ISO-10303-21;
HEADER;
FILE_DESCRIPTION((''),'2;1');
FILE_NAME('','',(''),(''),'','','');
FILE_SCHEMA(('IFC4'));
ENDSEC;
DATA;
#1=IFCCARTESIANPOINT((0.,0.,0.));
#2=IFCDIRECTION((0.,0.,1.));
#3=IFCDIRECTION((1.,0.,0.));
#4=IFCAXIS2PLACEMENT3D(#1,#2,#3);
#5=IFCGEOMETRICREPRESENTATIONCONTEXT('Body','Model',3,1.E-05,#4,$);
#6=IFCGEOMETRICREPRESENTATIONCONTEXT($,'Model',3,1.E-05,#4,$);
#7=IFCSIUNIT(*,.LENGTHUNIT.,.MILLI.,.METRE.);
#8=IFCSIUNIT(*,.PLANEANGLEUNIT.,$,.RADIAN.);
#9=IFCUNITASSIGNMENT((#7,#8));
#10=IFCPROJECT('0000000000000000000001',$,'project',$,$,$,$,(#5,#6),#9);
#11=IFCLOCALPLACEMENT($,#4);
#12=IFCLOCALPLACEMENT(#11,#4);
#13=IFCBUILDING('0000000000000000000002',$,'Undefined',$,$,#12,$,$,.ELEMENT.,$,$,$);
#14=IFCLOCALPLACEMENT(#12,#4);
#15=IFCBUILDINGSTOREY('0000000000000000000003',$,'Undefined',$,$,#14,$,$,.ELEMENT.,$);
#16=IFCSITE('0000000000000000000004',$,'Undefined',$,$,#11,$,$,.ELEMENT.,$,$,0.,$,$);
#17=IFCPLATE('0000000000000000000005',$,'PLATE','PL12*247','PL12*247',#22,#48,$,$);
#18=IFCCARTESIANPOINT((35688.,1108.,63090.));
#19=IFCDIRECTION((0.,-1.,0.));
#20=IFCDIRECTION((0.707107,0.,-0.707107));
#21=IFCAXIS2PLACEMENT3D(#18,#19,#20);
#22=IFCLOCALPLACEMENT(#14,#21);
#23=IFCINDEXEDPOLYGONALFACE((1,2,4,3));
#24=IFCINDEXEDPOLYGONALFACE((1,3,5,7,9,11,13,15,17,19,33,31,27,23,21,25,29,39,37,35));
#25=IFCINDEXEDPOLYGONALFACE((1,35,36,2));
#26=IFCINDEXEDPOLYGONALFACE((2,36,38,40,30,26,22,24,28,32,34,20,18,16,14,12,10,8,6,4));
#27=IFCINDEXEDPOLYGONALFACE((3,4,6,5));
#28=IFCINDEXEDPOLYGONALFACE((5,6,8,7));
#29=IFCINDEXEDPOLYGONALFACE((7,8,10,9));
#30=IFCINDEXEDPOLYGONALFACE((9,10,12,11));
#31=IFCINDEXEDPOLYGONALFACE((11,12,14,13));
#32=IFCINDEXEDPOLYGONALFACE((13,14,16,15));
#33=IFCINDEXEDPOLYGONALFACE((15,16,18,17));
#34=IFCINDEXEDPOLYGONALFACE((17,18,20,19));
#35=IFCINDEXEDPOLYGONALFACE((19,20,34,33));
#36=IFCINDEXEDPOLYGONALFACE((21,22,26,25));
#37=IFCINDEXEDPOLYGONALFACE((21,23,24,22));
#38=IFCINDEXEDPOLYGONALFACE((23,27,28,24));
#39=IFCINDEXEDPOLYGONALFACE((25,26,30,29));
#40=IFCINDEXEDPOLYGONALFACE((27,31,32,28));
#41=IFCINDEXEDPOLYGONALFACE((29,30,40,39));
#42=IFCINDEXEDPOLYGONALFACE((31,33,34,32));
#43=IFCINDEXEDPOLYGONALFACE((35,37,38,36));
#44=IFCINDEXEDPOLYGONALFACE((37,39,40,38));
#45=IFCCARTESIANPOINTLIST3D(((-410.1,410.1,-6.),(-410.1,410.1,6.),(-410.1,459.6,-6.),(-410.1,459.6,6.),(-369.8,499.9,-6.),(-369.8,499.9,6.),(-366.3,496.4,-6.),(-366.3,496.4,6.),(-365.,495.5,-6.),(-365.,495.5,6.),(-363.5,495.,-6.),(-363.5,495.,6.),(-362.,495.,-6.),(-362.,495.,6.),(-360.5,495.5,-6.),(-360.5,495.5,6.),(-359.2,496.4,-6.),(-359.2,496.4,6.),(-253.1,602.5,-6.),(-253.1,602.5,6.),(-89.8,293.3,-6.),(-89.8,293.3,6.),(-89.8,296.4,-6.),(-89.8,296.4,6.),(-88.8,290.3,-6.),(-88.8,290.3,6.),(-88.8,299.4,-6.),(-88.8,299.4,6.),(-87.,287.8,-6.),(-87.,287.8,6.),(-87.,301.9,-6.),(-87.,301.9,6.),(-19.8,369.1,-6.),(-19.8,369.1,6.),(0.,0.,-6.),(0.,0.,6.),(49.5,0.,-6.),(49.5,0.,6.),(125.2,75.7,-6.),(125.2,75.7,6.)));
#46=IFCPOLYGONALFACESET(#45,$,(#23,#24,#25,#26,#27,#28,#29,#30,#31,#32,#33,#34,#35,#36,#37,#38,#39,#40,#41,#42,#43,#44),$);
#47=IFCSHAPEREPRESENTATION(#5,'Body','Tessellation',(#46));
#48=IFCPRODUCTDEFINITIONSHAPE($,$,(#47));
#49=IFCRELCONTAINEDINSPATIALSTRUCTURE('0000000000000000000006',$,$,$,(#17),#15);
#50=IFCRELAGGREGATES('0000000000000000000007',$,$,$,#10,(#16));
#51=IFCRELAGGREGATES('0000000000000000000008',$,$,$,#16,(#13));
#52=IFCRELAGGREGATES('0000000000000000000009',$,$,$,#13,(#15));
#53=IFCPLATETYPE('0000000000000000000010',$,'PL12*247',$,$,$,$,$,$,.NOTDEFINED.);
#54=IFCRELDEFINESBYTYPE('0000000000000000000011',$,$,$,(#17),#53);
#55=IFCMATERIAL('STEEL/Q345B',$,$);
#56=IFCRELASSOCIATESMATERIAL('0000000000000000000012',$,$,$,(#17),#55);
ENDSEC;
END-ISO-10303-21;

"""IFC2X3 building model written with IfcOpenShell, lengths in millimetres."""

from ifc_helpers import new_model, si_unit, frame, origin_with_axes, place, context, project, spatial, polyline, outline, extrude, material, type_object, element, save


model = new_model("IFC2X3")

# Units and contexts
model_context_1 = context("Model", 3, precision=1e-05, world=origin_with_axes(), identifier="Body")
model_context_2 = context("Model", 3, precision=1e-05, world=origin_with_axes())
ifc_project = project(units=[si_unit("LENGTHUNIT", "METRE", prefix="MILLI"), si_unit("PLANEANGLEUNIT", "RADIAN")], contexts=[model_context_1, model_context_2])

# Site, building, storey
site_placement = place(None, origin_with_axes())
site = spatial("IfcSite", under=ifc_project, at=site_placement, Name="Undefined", CompositionType="ELEMENT", RefElevation=0.0)
building_placement = place(site_placement, origin_with_axes())
building = spatial("IfcBuilding", under=site, at=building_placement, Name="Undefined", CompositionType="ELEMENT")
storey_placement = place(building_placement, origin_with_axes())
storey = spatial("IfcBuildingStorey", under=building, at=storey_placement, Name="Undefined", CompositionType="ELEMENT")

# Shared definitions
ifc_material_1 = material(Name="STEEL/Q345B")

# Plate
plate_type_1 = type_object("IfcPlateType", Name="PL12*247", PredefinedType="NOTDEFINED")
plate_1_placement = place(storey_placement, frame((35688.0, 1108.0, 63090.0), z_axis=(0.0, -1.0, 0.0), x_axis=(0.707107, 0.0, -0.707107)))
element("IfcPlate", 1, at=plate_1_placement, inside=storey, type_object=plate_type_1, material=ifc_material_1, Name="PLATE", Description="PL12*247", ObjectType="PL12*247", context=model_context_1, shape_type="SweptSolid", body=[
    extrude(outline(polyline([(0.0, 0.0), (49.5, 0.0), (125.2, 75.7), (-87.0, 287.8), (-88.8, 290.3), (-89.8, 293.3), (-89.8, 296.4), (-88.8, 299.4), (-87.0, 301.9), (-19.8, 369.1), (-253.1, 602.5), (-359.2, 496.4), (-360.5, 495.5), (-362.0, 495.0), (-363.5, 495.0), (-365.0, 495.5), (-366.3, 496.4), (-369.8, 499.9), (-410.1, 459.6), (-410.1, 410.1), (0.0, 0.0)])), frame((0.0, 0.0, -6.0), z_axis=(0.0, 0.0, 1.0), x_axis=(1.0, 0.0, 0.0)), (0.0, 0.0, 1.0), 12.0),
])

save(model, "model.ifc")
